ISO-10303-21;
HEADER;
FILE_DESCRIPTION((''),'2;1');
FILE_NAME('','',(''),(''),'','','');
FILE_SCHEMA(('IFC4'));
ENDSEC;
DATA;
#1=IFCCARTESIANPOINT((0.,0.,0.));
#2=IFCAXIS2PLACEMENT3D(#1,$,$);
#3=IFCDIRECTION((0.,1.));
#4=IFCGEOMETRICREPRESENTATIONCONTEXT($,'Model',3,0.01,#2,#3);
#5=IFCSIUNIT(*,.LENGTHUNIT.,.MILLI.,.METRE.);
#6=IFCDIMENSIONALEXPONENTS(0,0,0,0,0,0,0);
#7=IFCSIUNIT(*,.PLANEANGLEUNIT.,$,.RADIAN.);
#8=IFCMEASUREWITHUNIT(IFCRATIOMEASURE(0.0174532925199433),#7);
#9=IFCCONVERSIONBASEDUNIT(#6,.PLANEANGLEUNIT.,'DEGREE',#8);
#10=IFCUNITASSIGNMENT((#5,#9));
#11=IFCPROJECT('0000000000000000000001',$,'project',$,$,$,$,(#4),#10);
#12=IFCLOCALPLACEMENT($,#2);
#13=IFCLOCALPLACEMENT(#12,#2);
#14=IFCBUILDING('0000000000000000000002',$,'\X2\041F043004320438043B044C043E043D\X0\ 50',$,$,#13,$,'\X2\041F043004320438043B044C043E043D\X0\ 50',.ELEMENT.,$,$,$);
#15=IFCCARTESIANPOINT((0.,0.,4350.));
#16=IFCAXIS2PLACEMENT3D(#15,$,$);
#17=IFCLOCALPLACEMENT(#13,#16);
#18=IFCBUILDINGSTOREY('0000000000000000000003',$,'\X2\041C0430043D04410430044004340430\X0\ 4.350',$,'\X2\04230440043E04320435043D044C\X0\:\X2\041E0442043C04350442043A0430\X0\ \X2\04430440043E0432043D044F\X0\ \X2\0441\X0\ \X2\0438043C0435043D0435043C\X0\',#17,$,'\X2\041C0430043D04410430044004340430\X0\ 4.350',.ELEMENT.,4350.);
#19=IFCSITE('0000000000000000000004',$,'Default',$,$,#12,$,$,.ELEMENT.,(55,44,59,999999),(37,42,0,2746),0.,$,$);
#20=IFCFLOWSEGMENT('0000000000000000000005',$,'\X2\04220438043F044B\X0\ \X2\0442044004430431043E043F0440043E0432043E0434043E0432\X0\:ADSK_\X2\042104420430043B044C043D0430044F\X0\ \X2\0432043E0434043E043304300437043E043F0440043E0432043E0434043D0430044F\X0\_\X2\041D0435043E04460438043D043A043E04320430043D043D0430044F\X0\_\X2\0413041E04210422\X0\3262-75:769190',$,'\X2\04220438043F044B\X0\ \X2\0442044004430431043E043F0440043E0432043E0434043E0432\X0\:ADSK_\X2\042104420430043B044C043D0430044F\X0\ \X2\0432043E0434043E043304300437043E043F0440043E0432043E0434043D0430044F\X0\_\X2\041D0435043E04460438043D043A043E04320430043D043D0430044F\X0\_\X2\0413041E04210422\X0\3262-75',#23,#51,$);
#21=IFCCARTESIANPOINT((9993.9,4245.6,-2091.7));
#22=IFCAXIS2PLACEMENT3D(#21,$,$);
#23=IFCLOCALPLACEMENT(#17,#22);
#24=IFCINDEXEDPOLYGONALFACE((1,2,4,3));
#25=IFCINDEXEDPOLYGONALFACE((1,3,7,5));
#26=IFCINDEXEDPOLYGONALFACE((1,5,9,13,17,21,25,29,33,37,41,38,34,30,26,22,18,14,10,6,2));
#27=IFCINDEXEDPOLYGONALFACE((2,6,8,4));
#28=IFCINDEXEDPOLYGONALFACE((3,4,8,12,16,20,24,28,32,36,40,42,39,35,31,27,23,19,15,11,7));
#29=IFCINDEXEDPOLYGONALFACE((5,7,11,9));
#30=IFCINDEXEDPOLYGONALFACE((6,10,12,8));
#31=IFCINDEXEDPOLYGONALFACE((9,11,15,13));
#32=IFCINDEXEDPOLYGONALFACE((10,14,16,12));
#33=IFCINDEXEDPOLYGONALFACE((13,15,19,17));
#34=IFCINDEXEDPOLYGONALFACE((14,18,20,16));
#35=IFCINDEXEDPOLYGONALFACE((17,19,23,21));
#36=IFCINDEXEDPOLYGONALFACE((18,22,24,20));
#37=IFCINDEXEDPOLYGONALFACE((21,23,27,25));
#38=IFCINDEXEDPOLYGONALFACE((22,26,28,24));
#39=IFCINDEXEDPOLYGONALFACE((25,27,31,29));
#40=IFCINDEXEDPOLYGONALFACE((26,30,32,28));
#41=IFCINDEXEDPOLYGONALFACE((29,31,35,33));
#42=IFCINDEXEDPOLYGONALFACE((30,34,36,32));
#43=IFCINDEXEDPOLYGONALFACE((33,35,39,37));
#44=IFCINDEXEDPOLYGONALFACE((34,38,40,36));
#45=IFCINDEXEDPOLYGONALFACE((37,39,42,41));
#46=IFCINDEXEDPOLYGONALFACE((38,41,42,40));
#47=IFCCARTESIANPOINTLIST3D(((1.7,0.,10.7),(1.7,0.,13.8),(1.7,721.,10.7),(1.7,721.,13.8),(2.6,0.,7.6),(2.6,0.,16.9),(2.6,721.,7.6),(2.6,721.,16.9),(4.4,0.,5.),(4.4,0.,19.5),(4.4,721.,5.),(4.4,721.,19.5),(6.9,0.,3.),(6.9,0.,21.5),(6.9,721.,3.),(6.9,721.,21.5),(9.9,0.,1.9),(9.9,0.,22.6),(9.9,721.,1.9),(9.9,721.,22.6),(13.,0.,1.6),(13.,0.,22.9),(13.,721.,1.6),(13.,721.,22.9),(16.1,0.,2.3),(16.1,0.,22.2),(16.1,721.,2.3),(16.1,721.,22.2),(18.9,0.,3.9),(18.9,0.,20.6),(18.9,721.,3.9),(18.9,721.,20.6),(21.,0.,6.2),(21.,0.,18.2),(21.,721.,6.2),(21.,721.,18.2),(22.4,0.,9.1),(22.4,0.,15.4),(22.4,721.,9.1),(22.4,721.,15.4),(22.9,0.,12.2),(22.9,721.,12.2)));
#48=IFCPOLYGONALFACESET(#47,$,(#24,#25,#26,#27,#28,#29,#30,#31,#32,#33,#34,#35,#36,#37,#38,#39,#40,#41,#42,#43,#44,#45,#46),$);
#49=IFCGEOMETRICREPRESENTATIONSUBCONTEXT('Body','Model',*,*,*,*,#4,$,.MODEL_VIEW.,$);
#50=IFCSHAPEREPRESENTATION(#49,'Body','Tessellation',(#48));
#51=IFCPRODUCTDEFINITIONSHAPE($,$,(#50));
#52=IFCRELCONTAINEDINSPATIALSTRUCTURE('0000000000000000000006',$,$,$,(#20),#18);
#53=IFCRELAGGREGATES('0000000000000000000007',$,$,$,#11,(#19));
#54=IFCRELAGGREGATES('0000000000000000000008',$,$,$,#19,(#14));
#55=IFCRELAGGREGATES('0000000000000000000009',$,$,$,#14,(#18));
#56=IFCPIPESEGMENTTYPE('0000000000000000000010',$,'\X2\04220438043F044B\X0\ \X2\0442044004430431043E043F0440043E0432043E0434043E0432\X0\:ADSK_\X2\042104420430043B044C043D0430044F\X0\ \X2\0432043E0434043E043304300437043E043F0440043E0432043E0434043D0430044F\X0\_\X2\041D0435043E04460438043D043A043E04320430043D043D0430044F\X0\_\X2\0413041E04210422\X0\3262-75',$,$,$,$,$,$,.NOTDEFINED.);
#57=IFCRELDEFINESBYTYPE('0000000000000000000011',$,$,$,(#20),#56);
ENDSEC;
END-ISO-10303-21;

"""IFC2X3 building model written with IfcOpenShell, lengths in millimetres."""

from ifc_helpers import new_model, entity, si_unit, converted_unit, direction, frame, origin, origin_2d_with_axis, place, context, subcontext, project, spatial, circle, extrude, type_object, element, save


model = new_model("IFC2X3")

# Units and contexts
model_context = context("Model", 3, precision=0.01, world=origin(), true_north=direction((0.0, 1.0)))
body_context = subcontext(model_context, "Body", "Model", "MODEL_VIEW")
ifc_project = project(units=[si_unit("LENGTHUNIT", "METRE", prefix="MILLI"), converted_unit("PLANEANGLEUNIT", "DEGREE", entity("IfcRatioMeasure", 0.0174532925199433), si_unit("PLANEANGLEUNIT", "RADIAN"), dimensions=[0, 0, 0, 0, 0, 0, 0])], contexts=[model_context])

# Site, building, storey
site_placement = place(None, origin())
site = spatial("IfcSite", under=ifc_project, at=site_placement, Name="Default", CompositionType="ELEMENT", RefLatitude=(55, 44, 59, 999999), RefLongitude=(37, 42, 0, 2746), RefElevation=0.0)
building_placement = place(site_placement, origin())
building = spatial("IfcBuilding", under=site, at=building_placement, Name="Павильон 50", LongName="Павильон 50", CompositionType="ELEMENT")
storey_placement = place(building_placement, frame((0.0, 0.0, 4350.0)))
storey = spatial("IfcBuildingStorey", under=building, at=storey_placement, Name="Мансарда 4.350", ObjectType="Уровень:Отметка уровня с именем", LongName="Мансарда 4.350", CompositionType="ELEMENT", Elevation=4350.0)

# Flow segment
pipe_segment_type = type_object("IfcPipeSegmentType", Name="Типы трубопроводов:ADSK_Стальная водогазопроводная_Неоцинкованная_ГОСТ3262-75", PredefinedType="NOTDEFINED")
flow_segment_1_placement = place(storey_placement, frame((9993.9, 4245.6, -2091.7)))
element("IfcFlowSegment", 1, at=flow_segment_1_placement, inside=storey, type_object=pipe_segment_type, Name="Типы трубопроводов:ADSK_Стальная водогазопроводная_Неоцинкованная_ГОСТ3262-75:769190", ObjectType="Типы трубопроводов:ADSK_Стальная водогазопроводная_Неоцинкованная_ГОСТ3262-75", context=body_context, shape_type="SweptSolid", body=[
    extrude(circle(Radius=10.7, at=origin_2d_with_axis()), frame((12.2, 0.0, 12.2), z_axis=(0.0, 1.0, 0.0), x_axis=(1.0, 0.0, 0.0)), (0.0, 0.0, 1.0), 721.0),
])

save(model, "model.ifc")
